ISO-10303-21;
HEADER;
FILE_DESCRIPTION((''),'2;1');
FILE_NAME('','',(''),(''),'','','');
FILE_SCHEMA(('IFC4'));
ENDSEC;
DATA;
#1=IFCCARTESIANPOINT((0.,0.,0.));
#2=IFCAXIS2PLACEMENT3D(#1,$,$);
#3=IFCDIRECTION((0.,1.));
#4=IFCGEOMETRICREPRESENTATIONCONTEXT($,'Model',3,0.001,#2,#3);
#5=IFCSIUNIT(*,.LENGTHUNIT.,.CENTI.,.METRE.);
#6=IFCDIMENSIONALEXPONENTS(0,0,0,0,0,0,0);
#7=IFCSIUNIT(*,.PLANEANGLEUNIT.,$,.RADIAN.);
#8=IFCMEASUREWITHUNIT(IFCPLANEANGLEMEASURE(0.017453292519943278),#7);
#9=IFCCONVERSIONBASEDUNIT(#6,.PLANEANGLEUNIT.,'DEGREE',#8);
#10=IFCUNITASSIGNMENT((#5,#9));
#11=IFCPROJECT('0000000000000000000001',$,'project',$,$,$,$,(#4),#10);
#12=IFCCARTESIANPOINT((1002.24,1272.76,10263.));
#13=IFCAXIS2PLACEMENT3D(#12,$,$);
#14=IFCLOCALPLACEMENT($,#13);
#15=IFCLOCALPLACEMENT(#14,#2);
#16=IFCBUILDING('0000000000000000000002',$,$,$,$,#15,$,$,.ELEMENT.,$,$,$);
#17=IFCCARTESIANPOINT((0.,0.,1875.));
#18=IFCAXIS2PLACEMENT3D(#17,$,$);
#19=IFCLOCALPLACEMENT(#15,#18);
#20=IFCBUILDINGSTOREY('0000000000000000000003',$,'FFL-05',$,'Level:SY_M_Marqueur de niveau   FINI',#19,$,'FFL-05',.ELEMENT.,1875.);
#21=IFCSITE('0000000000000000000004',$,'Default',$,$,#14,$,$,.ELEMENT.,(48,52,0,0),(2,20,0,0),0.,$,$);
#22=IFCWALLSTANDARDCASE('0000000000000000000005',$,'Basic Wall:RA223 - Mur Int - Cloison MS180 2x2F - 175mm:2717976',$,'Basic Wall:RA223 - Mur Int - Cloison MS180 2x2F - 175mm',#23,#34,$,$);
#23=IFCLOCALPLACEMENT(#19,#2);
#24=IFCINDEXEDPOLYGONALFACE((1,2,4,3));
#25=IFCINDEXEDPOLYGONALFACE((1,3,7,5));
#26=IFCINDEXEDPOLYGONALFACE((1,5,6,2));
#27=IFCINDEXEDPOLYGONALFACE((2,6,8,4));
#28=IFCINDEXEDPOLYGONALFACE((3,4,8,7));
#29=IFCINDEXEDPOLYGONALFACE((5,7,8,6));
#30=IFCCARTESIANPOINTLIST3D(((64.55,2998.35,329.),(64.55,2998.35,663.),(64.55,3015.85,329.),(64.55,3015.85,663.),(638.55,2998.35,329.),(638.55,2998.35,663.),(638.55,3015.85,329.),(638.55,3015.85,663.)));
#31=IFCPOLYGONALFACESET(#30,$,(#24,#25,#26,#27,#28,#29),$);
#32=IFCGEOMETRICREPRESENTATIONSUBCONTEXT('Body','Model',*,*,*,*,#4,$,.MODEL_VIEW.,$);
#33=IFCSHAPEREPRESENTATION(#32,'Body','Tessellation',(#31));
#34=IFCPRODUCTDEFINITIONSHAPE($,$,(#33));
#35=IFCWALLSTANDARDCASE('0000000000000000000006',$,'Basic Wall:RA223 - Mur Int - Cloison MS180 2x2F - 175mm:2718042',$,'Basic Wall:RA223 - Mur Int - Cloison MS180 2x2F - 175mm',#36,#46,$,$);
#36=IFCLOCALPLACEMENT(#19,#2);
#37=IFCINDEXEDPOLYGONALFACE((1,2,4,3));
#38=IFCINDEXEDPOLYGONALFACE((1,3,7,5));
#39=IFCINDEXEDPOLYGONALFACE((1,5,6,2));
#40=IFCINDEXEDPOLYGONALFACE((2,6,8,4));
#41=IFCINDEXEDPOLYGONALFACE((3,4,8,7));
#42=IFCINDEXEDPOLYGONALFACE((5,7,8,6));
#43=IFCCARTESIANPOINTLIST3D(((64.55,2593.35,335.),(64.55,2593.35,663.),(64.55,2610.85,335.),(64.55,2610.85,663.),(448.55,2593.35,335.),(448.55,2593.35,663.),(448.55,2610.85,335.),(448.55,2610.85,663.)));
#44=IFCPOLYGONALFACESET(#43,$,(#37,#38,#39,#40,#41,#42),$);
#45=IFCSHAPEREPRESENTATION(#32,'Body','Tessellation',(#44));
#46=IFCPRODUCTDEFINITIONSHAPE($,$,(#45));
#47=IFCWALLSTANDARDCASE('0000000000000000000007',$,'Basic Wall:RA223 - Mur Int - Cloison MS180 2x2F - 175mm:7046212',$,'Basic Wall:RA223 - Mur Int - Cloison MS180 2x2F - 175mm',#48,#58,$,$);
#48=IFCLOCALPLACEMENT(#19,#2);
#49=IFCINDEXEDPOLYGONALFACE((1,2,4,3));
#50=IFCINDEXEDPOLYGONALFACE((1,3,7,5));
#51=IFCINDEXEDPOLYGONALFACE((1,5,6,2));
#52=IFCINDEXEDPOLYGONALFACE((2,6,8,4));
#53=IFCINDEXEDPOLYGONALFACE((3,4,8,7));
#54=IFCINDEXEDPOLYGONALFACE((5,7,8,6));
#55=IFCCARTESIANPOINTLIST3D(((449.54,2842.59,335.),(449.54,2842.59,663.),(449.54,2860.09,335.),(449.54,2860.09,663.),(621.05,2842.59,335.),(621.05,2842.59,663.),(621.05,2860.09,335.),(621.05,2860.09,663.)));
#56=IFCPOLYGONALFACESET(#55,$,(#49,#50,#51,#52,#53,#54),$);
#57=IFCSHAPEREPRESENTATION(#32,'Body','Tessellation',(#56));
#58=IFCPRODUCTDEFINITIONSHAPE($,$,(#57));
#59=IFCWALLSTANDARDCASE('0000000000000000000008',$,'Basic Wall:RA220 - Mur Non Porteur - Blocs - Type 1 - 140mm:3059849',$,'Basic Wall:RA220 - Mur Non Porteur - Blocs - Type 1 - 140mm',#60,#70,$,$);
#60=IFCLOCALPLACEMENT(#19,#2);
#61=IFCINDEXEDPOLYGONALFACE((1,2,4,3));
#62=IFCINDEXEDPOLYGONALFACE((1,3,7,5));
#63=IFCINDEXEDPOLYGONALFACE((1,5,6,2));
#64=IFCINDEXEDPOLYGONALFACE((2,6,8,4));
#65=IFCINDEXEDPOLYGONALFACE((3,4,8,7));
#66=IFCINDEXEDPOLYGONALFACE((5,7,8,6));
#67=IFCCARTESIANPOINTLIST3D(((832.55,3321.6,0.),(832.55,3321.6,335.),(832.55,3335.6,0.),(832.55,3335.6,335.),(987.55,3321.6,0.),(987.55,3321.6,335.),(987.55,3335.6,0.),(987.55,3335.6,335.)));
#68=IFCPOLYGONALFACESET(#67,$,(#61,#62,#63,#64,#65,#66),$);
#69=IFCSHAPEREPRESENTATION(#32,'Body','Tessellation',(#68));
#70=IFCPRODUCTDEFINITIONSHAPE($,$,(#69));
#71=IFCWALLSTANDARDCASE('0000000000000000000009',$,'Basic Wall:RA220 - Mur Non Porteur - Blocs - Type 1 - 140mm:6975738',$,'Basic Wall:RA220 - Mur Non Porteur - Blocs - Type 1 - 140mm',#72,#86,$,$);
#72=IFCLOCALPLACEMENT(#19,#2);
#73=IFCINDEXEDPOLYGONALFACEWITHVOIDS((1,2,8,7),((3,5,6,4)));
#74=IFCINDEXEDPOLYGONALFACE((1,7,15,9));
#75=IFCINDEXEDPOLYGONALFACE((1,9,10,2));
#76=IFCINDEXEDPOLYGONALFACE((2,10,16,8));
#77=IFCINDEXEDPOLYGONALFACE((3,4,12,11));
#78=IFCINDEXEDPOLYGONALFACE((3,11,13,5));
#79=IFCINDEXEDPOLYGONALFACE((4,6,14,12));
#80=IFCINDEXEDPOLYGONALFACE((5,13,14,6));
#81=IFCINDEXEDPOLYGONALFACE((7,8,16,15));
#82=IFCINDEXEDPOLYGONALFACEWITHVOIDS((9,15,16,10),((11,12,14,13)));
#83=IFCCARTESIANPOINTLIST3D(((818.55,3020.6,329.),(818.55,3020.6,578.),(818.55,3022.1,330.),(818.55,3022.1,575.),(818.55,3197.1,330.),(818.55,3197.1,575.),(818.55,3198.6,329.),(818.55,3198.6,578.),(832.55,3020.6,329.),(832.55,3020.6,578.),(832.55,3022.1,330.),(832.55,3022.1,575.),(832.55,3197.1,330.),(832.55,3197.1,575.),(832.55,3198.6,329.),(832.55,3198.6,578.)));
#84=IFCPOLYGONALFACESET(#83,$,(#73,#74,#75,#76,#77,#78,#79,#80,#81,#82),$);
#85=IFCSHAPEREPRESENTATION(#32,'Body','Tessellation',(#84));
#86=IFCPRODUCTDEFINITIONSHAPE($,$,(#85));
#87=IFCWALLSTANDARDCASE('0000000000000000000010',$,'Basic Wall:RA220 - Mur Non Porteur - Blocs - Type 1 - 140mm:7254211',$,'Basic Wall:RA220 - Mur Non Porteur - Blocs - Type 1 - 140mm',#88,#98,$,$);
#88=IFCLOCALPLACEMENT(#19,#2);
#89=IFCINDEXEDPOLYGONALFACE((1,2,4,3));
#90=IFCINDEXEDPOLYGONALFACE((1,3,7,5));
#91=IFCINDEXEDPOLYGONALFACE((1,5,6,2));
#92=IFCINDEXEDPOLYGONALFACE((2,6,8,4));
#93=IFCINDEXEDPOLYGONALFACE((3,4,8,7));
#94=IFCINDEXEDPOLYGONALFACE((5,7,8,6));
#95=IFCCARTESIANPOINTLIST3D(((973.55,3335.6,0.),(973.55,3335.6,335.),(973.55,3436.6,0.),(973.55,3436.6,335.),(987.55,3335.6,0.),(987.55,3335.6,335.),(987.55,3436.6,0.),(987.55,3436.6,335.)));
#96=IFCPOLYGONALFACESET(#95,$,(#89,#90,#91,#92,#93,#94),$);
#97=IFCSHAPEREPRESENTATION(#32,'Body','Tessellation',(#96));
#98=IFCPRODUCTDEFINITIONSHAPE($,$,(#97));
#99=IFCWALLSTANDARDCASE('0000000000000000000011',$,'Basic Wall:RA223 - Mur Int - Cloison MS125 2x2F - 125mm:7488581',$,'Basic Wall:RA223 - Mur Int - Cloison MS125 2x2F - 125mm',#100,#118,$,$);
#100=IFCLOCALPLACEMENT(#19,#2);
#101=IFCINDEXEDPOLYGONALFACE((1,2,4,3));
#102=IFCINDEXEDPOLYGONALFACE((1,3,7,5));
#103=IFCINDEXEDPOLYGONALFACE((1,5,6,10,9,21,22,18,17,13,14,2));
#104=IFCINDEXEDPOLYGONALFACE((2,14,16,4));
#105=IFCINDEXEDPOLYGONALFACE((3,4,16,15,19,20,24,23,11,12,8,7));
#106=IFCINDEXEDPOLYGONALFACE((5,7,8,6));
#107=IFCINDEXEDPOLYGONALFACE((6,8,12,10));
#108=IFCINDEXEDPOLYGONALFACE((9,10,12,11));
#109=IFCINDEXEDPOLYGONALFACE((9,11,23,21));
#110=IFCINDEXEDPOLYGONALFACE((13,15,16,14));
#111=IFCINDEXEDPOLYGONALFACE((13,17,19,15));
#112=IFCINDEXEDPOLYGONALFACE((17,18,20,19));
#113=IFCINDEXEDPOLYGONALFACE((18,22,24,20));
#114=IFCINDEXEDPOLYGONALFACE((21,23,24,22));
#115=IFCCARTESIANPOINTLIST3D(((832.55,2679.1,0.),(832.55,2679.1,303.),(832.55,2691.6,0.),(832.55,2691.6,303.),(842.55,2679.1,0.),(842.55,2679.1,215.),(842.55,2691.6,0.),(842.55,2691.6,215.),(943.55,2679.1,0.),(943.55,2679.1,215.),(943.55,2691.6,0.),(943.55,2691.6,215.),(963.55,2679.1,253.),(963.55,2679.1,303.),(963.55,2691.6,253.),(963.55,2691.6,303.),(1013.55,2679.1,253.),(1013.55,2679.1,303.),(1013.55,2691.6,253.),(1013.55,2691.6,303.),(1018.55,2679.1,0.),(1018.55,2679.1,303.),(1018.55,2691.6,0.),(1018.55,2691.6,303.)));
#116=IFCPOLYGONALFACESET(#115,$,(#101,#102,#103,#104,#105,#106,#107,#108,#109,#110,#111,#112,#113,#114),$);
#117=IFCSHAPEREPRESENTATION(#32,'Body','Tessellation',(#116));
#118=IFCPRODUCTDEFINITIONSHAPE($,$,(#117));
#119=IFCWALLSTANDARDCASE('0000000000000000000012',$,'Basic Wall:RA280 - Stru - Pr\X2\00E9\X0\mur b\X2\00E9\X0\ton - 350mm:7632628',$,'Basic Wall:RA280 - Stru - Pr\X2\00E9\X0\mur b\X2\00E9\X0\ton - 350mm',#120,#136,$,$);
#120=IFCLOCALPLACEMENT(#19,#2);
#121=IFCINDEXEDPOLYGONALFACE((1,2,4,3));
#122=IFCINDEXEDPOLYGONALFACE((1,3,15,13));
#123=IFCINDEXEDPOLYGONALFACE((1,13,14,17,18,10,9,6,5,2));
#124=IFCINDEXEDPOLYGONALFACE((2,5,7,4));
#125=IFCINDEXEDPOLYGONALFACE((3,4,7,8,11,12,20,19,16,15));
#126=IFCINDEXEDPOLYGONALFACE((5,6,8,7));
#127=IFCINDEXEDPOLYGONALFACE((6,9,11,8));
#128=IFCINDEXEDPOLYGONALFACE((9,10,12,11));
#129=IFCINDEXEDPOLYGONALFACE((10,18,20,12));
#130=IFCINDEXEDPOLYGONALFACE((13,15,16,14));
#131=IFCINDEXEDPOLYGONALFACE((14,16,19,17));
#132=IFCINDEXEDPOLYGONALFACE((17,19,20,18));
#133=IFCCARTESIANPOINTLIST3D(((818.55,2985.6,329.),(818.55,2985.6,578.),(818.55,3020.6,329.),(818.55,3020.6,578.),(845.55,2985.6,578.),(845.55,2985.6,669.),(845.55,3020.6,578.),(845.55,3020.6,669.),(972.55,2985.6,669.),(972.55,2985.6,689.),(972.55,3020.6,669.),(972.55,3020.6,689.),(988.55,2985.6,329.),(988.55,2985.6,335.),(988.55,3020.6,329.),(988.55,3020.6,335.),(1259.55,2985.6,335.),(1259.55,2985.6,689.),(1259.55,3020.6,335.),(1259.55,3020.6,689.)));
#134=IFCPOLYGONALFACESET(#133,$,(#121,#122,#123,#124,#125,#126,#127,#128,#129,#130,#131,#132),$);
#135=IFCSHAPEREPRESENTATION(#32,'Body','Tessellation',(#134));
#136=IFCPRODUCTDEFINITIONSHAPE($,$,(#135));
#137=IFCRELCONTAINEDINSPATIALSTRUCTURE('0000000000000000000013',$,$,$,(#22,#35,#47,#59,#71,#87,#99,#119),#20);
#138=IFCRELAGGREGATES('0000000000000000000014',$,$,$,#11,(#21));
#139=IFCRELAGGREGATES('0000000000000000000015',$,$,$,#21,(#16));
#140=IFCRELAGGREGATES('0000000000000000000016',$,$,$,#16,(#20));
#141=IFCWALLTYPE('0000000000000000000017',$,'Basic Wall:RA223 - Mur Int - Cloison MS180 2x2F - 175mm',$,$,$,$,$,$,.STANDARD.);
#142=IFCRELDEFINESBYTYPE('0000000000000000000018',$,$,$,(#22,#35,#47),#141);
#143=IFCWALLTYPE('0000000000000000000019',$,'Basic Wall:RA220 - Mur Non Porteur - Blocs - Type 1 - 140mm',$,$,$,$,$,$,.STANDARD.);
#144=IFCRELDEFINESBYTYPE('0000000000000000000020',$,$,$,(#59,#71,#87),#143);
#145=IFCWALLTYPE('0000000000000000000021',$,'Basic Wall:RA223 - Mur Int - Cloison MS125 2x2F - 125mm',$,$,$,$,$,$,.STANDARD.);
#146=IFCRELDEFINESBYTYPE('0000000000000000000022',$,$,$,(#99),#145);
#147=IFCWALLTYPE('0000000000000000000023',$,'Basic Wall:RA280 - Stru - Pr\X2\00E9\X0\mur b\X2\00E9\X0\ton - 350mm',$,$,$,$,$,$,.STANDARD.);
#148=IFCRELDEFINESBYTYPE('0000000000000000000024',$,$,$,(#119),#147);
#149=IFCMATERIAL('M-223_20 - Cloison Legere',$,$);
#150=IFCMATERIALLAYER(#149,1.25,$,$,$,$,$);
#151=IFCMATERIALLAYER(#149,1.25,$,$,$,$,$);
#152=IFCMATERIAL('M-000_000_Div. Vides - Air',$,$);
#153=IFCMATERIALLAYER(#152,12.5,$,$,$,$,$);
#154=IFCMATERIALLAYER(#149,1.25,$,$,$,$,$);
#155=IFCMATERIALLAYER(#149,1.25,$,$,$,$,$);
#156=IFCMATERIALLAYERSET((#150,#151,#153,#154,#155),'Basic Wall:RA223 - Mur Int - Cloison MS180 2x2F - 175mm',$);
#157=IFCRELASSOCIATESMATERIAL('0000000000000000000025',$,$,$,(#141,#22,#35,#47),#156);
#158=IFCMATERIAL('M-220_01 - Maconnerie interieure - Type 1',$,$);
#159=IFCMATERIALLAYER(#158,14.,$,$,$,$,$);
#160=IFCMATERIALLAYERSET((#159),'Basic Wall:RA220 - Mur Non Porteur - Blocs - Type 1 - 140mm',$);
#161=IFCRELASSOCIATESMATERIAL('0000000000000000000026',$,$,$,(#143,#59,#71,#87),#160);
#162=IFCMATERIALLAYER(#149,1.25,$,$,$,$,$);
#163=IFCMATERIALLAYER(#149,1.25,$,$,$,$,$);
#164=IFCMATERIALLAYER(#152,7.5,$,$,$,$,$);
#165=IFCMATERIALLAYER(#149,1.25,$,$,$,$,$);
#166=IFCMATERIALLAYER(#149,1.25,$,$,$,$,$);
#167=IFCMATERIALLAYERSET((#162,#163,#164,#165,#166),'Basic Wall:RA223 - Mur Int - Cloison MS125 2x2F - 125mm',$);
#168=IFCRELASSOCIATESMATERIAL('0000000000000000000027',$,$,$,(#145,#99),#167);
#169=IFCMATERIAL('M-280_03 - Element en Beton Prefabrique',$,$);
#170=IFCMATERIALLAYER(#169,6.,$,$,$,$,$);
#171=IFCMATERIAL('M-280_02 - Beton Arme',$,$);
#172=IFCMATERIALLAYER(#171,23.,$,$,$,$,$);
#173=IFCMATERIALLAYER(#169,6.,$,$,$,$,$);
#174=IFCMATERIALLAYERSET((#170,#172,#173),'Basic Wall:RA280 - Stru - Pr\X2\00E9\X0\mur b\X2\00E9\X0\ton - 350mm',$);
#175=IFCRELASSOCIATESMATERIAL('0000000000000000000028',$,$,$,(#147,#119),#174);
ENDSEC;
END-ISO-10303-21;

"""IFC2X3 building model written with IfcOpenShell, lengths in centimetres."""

from ifc_helpers import new_model, entity, si_unit, converted_unit, direction, frame, frame_2d, origin, place, context, subcontext, project, spatial, polyline, rectangle, extrude, clip, bounded_halfspace, material, layer, layer_set, layer_usage, type_object, element, save


model = new_model("IFC2X3")

# Units and contexts
model_context = context("Model", 3, precision=0.001, world=origin(), true_north=direction((0.0, 1.0)))
body_context = subcontext(model_context, "Body", "Model", "MODEL_VIEW")
ifc_project = project(units=[si_unit("LENGTHUNIT", "METRE", prefix="CENTI"), converted_unit("PLANEANGLEUNIT", "DEGREE", entity("IfcPlaneAngleMeasure", 0.017453292519943278), si_unit("PLANEANGLEUNIT", "RADIAN"), dimensions=[0, 0, 0, 0, 0, 0, 0])], contexts=[model_context])

# Site, building, storey
site_placement = place(None, frame((1002.24, 1272.76, 10263.0)))
site = spatial("IfcSite", under=ifc_project, at=site_placement, Name="Default", CompositionType="ELEMENT", RefLatitude=(48, 52, 0, 0), RefLongitude=(2, 20, 0, 0), RefElevation=0.0)
building_placement = place(site_placement, origin())
building = spatial("IfcBuilding", under=site, at=building_placement, CompositionType="ELEMENT")
storey_placement = place(building_placement, frame((0.0, 0.0, 1875.0)))
storey = spatial("IfcBuildingStorey", under=building, at=storey_placement, Name="FFL-05", ObjectType="Level:SY_M_Marqueur de niveau   FINI", LongName="FFL-05", CompositionType="ELEMENT", Elevation=1875.0)

# Shared definitions
ifc_material_1 = material(Name="M-280_02 - Beton Arme")

# Walls
ifc_material_2 = material(Name="M-223_20 - Cloison Legere")
ifc_layer_1 = layer(ifc_material_2, 1.25)
ifc_layer_2 = layer(ifc_material_2, 1.25)
ifc_material_3 = material(Name="M-000_000_Div. Vides - Air")
ifc_layer_3 = layer(ifc_material_3, 12.5)
ifc_layer_4 = layer(ifc_material_2, 1.25)
ifc_layer_5 = layer(ifc_material_2, 1.25)
ifc_layer_set_1 = layer_set([ifc_layer_1, ifc_layer_2, ifc_layer_3, ifc_layer_4, ifc_layer_5], Name="Basic Wall:RA223 - Mur Int - Cloison MS180 2x2F - 175mm")
ifc_layer_usage_1 = layer_usage(ifc_layer_set_1, "AXIS2", "NEGATIVE", 8.75)
wall_type_1 = type_object("IfcWallType", Name="Basic Wall:RA223 - Mur Int - Cloison MS180 2x2F - 175mm", PredefinedType="STANDARD", material=ifc_layer_set_1)
wall_1_placement = place(storey_placement, frame((64.55, 3007.1, 329.0)))
element("IfcWallStandardCase", 1, at=wall_1_placement, inside=storey, type_object=wall_type_1, material=ifc_layer_usage_1, Name="Basic Wall:RA223 - Mur Int - Cloison MS180 2x2F - 175mm:2717976", ObjectType="Basic Wall:RA223 - Mur Int - Cloison MS180 2x2F - 175mm", context=body_context, shape_type="Clipping", body=[
    clip(clip(extrude(rectangle(XDim=574.01, YDim=17.5, at=frame_2d((287.0, 0.0), x_axis=(-1.0, 0.0))), origin(), (0.0, 0.0, 1.0), 334.0), bounded_halfspace(frame((0.0, -8.75, 334.0), z_axis=(0.0, 0.0, -1.0), x_axis=(1.0, 0.0, 0.0)), True, frame((0.0, -8.75, 334.0)), polyline([(0.0, 0.0), (556.51, 0.0), (574.01, 0.0), (574.01, 17.5), (0.0, 17.5), (0.0, 0.0)]))), bounded_halfspace(frame((574.01, -8.75, 0.0), z_axis=(0.0, 0.0, 1.0), x_axis=(-1.0, 0.0, 0.0)), True, frame((574.01, -8.75, 0.0)), polyline([(0.0, 0.0), (0.0, 17.5), (-574.01, 17.5), (-574.01, 0.0), (0.0, 0.0)]))),
])
ifc_layer_usage_2 = layer_usage(ifc_layer_set_1, "AXIS2", "NEGATIVE", 8.75)
wall_2_placement = place(storey_placement, frame((64.55, 2602.1, 335.0)))
element("IfcWallStandardCase", 2, at=wall_2_placement, inside=storey, type_object=wall_type_1, material=ifc_layer_usage_2, Name="Basic Wall:RA223 - Mur Int - Cloison MS180 2x2F - 175mm:2718042", ObjectType="Basic Wall:RA223 - Mur Int - Cloison MS180 2x2F - 175mm", context=body_context, shape_type="Clipping", body=[
    clip(clip(extrude(rectangle(XDim=384.0, YDim=17.5, at=frame_2d((192.0, 0.0), x_axis=(-1.0, 0.0))), origin(), (0.0, 0.0, 1.0), 328.0), bounded_halfspace(frame((0.0, -8.75, 328.0), z_axis=(0.0, 0.0, -1.0), x_axis=(1.0, 0.0, 0.0)), True, frame((0.0, -8.75, 328.0)), polyline([(0.0, 0.0), (384.0, 0.0), (384.0, 17.5), (0.0, 17.5), (0.0, 0.0)]))), bounded_halfspace(frame((384.0, -8.75, 0.0), z_axis=(0.0, 0.0, 1.0), x_axis=(-1.0, 0.0, 0.0)), True, frame((384.0, -8.75, 0.0)), polyline([(0.0, 0.0), (0.0, 17.5), (-384.0, 17.5), (-384.0, 0.0), (0.0, 0.0)]))),
])

# Walls
ifc_layer_usage_3 = layer_usage(ifc_layer_set_1, "AXIS2", "POSITIVE", -8.75)
wall_3_placement = place(storey_placement, frame((449.54, 2851.34, 335.0)))
element("IfcWallStandardCase", 3, at=wall_3_placement, inside=storey, type_object=wall_type_1, material=ifc_layer_usage_3, Name="Basic Wall:RA223 - Mur Int - Cloison MS180 2x2F - 175mm:7046212", ObjectType="Basic Wall:RA223 - Mur Int - Cloison MS180 2x2F - 175mm", context=body_context, shape_type="Clipping", body=[
    clip(clip(extrude(rectangle(XDim=171.51, YDim=17.5, at=frame_2d((85.76, 0.0), x_axis=(-1.0, 0.0))), origin(), (0.0, 0.0, 1.0), 328.0), bounded_halfspace(frame((0.0, -8.75, 328.0), z_axis=(0.0, 0.0, -1.0), x_axis=(1.0, 0.0, 0.0)), True, frame((0.0, -8.75, 328.0)), polyline([(0.0, 0.0), (17.5, 0.0), (171.51, 0.0), (171.51, 17.5), (0.0, 17.5), (0.0, 0.0)]))), bounded_halfspace(frame((171.51, -8.75, 0.0), z_axis=(0.0, 0.0, 1.0), x_axis=(-1.0, 0.0, 0.0)), True, frame((171.51, -8.75, 0.0)), polyline([(0.0, 0.0), (0.0, 17.5), (-171.51, 17.5), (-171.51, 0.0), (-154.01, 0.0), (0.0, 0.0)]))),
])
ifc_material_4 = material(Name="M-220_01 - Maconnerie interieure - Type 1")
ifc_layer_6 = layer(ifc_material_4, 14.0)
ifc_layer_set_2 = layer_set([ifc_layer_6], Name="Basic Wall:RA220 - Mur Non Porteur - Blocs - Type 1 - 140mm")
ifc_layer_usage_4 = layer_usage(ifc_layer_set_2, "AXIS2", "NEGATIVE", 7.0)
wall_type_2 = type_object("IfcWallType", Name="Basic Wall:RA220 - Mur Non Porteur - Blocs - Type 1 - 140mm", PredefinedType="STANDARD", material=ifc_layer_set_2)
wall_4_placement = place(storey_placement, frame((832.55, 3328.6, 0.0)))
element("IfcWallStandardCase", 4, at=wall_4_placement, inside=storey, type_object=wall_type_2, material=ifc_layer_usage_4, Name="Basic Wall:RA220 - Mur Non Porteur - Blocs - Type 1 - 140mm:3059849", ObjectType="Basic Wall:RA220 - Mur Non Porteur - Blocs - Type 1 - 140mm", context=body_context, shape_type="SweptSolid", body=[
    extrude(rectangle(XDim=154.99, YDim=14.0, at=frame_2d((77.5, 0.0), x_axis=(-1.0, 0.0))), origin(), (0.0, 0.0, 1.0), 335.0),
])

# Wall, opening
ifc_layer_usage_5 = layer_usage(ifc_layer_set_2, "AXIS2", "NEGATIVE", 7.0)
wall_5_placement = place(storey_placement, frame((825.55, 3198.6, 329.0), z_axis=(0.0, 0.0, 1.0), x_axis=(0.0, -1.0, 0.0)))
wall_5 = element("IfcWallStandardCase", 5, at=wall_5_placement, inside=storey, type_object=wall_type_2, material=ifc_layer_usage_5, Name="Basic Wall:RA220 - Mur Non Porteur - Blocs - Type 1 - 140mm:6975738", ObjectType="Basic Wall:RA220 - Mur Non Porteur - Blocs - Type 1 - 140mm", context=body_context, shape_type="SweptSolid", body=[
    extrude(rectangle(XDim=178.0, YDim=14.0, at=frame_2d((89.0, 0.0), x_axis=(-1.0, 0.0))), origin(), (0.0, 0.0, 1.0), 249.0),
])
opening_1_placement = place(wall_5_placement, frame((3198.6, -825.55, 31.0), z_axis=(0.0, 0.0, 1.0), x_axis=(0.0, 1.0, 0.0)))
element("IfcOpeningElement", 6, at=opening_1_placement, cuts=wall_5, ObjectType="Opening", context=body_context, shape_type="SweptSolid", body=[
    extrude(rectangle(XDim=245.0, YDim=175.0, at=frame_2d((0.0, 0.0), x_axis=(1.0, 0.0))), frame((818.55, 3109.6, 92.5), z_axis=(1.0, 0.0, 0.0), x_axis=(0.0, 0.0, -1.0)), (0.0, 0.0, 1.0), 14.0),
])

# Wall
ifc_layer_usage_6 = layer_usage(ifc_layer_set_2, "AXIS2", "NEGATIVE", 7.0)
wall_6_placement = place(storey_placement, frame((980.55, 3436.6, 0.0), z_axis=(0.0, 0.0, 1.0), x_axis=(0.0, -1.0, 0.0)))
element("IfcWallStandardCase", 7, at=wall_6_placement, inside=storey, type_object=wall_type_2, material=ifc_layer_usage_6, Name="Basic Wall:RA220 - Mur Non Porteur - Blocs - Type 1 - 140mm:7254211", ObjectType="Basic Wall:RA220 - Mur Non Porteur - Blocs - Type 1 - 140mm", context=body_context, shape_type="SweptSolid", body=[
    extrude(rectangle(XDim=101.0, YDim=14.0, at=frame_2d((50.5, 0.0), x_axis=(-1.0, 0.0))), origin(), (0.0, 0.0, 1.0), 335.0),
])

# Wall, opening
ifc_layer_7 = layer(ifc_material_2, 1.25)
ifc_layer_8 = layer(ifc_material_2, 1.25)
ifc_layer_9 = layer(ifc_material_3, 7.5)
ifc_layer_10 = layer(ifc_material_2, 1.25)
ifc_layer_11 = layer(ifc_material_2, 1.25)
ifc_layer_set_3 = layer_set([ifc_layer_7, ifc_layer_8, ifc_layer_9, ifc_layer_10, ifc_layer_11], Name="Basic Wall:RA223 - Mur Int - Cloison MS125 2x2F - 125mm")
ifc_layer_usage_7 = layer_usage(ifc_layer_set_3, "AXIS2", "POSITIVE", -6.25)
wall_type_3 = type_object("IfcWallType", Name="Basic Wall:RA223 - Mur Int - Cloison MS125 2x2F - 125mm", PredefinedType="STANDARD", material=ifc_layer_set_3)
wall_7_placement = place(storey_placement, frame((1018.55, 2685.35, 0.0), z_axis=(0.0, 0.0, 1.0), x_axis=(-1.0, 0.0, 0.0)))
wall_7 = element("IfcWallStandardCase", 8, at=wall_7_placement, inside=storey, type_object=wall_type_3, material=ifc_layer_usage_7, Name="Basic Wall:RA223 - Mur Int - Cloison MS125 2x2F - 125mm:7488581", ObjectType="Basic Wall:RA223 - Mur Int - Cloison MS125 2x2F - 125mm", context=body_context, shape_type="Clipping", body=[
    clip(extrude(rectangle(XDim=185.99, YDim=12.5, at=frame_2d((93.0, 0.0), x_axis=(1.0, 0.0))), origin(), (0.0, 0.0, 1.0), 303.0), bounded_halfspace(frame((55.0, -6.25, 253.0), z_axis=(0.0, 0.0, -1.0), x_axis=(0.0, -1.0, 0.0)), True, frame((55.0, -6.25, 253.0), z_axis=(0.0, 0.0, -1.0), x_axis=(0.0, -1.0, 0.0)), polyline([(0.0, 0.0), (0.0, 50.0), (-12.5, 50.0), (-12.5, 0.0), (0.0, 0.0)]))),
])
opening_2_placement = place(wall_7_placement, frame((1018.55, 2685.35, 0.0), z_axis=(0.0, 0.0, 1.0), x_axis=(-1.0, 0.0, 0.0)))
element("IfcOpeningElement", 9, at=opening_2_placement, cuts=wall_7, ObjectType="Opening", context=body_context, shape_type="SweptSolid", body=[
    extrude(rectangle(XDim=240.0, YDim=101.0, at=frame_2d((0.0, 0.0), x_axis=(0.0, 1.0))), frame((893.05, 2691.6, 95.0), z_axis=(0.0, -1.0, 0.0), x_axis=(-1.0, 0.0, 0.0)), (0.0, 0.0, 1.0), 13.5),
])

# Wall
ifc_material_5 = material(Name="M-280_03 - Element en Beton Prefabrique")
ifc_layer_12 = layer(ifc_material_5, 6.0)
ifc_layer_13 = layer(ifc_material_1, 23.0)
ifc_layer_14 = layer(ifc_material_5, 6.0)
ifc_layer_set_4 = layer_set([ifc_layer_12, ifc_layer_13, ifc_layer_14], Name="Basic Wall:RA280 - Stru - Prémur béton - 350mm")
ifc_layer_usage_8 = layer_usage(ifc_layer_set_4, "AXIS2", "NEGATIVE", 17.5)
wall_type_4 = type_object("IfcWallType", Name="Basic Wall:RA280 - Stru - Prémur béton - 350mm", PredefinedType="STANDARD", material=ifc_layer_set_4)
wall_8_placement = place(storey_placement, frame((818.55, 3003.1, 329.0)))
element("IfcWallStandardCase", 10, at=wall_8_placement, inside=storey, type_object=wall_type_4, material=ifc_layer_usage_8, Name="Basic Wall:RA280 - Stru - Prémur béton - 350mm:7632628", ObjectType="Basic Wall:RA280 - Stru - Prémur béton - 350mm", context=body_context, shape_type="Clipping", body=[
    clip(clip(clip(clip(clip(clip(extrude(rectangle(XDim=440.99, YDim=35.0, at=frame_2d((220.5, 0.0), x_axis=(-1.0, 0.0))), origin(), (0.0, 0.0, 1.0), 360.0), bounded_halfspace(frame((27.0, -17.5, 340.0), z_axis=(1.0, 0.0, 0.0), x_axis=(0.0, 0.0, 1.0)), True, frame((27.0, -17.5, 340.0), z_axis=(1.0, 0.0, 0.0), x_axis=(0.0, 0.0, 1.0)), polyline([(0.0, 0.0), (-6.0, 0.0), (-91.0, 0.0), (-91.0, -35.0), (0.0, -35.0), (0.0, 0.0)]))), bounded_halfspace(frame((153.99, -17.5, 340.0), z_axis=(0.0, 0.0, -1.0), x_axis=(1.0, 0.0, 0.0)), True, frame((153.99, -17.5, 340.0), z_axis=(0.0, 0.0, -1.0), x_axis=(1.0, 0.0, 0.0)), polyline([(0.0, 0.0), (-126.99, 0.0), (-126.99, -35.0), (0.0, -35.0), (0.0, 0.0)]))), bounded_halfspace(frame((153.99, 17.5, 340.0), z_axis=(1.0, 0.0, 0.0), x_axis=(0.0, 0.0, 1.0)), True, frame((153.99, 17.5, 340.0), z_axis=(1.0, 0.0, 0.0), x_axis=(0.0, 0.0, 1.0)), polyline([(0.0, 0.0), (20.0, 0.0), (20.0, 35.0), (0.0, 35.0), (0.0, 0.0)]))), bounded_halfspace(frame((169.99, -17.5, 6.0)), True, frame((169.99, -17.5, 6.0)), polyline([(0.0, 0.0), (271.0, 0.0), (271.0, 35.0), (0.0, 35.0), (0.0, 0.0)]))), bounded_halfspace(frame((169.99, 17.5, 6.0), z_axis=(-1.0, 0.0, 0.0), x_axis=(0.0, 0.0, 1.0)), True, frame((169.99, 17.5, 6.0), z_axis=(-1.0, 0.0, 0.0), x_axis=(0.0, 0.0, 1.0)), polyline([(0.0, 0.0), (-6.0, 0.0), (-6.0, -35.0), (0.0, -35.0), (0.0, 0.0)]))), bounded_halfspace(frame((27.0, -17.5, 249.0)), False, frame((27.0, -17.5, 249.0)), polyline([(0.0, 0.0), (0.0, 35.0), (-27.0, 35.0), (-27.0, 0.0), (0.0, 0.0)]))),
])

save(model, "model.ifc")
